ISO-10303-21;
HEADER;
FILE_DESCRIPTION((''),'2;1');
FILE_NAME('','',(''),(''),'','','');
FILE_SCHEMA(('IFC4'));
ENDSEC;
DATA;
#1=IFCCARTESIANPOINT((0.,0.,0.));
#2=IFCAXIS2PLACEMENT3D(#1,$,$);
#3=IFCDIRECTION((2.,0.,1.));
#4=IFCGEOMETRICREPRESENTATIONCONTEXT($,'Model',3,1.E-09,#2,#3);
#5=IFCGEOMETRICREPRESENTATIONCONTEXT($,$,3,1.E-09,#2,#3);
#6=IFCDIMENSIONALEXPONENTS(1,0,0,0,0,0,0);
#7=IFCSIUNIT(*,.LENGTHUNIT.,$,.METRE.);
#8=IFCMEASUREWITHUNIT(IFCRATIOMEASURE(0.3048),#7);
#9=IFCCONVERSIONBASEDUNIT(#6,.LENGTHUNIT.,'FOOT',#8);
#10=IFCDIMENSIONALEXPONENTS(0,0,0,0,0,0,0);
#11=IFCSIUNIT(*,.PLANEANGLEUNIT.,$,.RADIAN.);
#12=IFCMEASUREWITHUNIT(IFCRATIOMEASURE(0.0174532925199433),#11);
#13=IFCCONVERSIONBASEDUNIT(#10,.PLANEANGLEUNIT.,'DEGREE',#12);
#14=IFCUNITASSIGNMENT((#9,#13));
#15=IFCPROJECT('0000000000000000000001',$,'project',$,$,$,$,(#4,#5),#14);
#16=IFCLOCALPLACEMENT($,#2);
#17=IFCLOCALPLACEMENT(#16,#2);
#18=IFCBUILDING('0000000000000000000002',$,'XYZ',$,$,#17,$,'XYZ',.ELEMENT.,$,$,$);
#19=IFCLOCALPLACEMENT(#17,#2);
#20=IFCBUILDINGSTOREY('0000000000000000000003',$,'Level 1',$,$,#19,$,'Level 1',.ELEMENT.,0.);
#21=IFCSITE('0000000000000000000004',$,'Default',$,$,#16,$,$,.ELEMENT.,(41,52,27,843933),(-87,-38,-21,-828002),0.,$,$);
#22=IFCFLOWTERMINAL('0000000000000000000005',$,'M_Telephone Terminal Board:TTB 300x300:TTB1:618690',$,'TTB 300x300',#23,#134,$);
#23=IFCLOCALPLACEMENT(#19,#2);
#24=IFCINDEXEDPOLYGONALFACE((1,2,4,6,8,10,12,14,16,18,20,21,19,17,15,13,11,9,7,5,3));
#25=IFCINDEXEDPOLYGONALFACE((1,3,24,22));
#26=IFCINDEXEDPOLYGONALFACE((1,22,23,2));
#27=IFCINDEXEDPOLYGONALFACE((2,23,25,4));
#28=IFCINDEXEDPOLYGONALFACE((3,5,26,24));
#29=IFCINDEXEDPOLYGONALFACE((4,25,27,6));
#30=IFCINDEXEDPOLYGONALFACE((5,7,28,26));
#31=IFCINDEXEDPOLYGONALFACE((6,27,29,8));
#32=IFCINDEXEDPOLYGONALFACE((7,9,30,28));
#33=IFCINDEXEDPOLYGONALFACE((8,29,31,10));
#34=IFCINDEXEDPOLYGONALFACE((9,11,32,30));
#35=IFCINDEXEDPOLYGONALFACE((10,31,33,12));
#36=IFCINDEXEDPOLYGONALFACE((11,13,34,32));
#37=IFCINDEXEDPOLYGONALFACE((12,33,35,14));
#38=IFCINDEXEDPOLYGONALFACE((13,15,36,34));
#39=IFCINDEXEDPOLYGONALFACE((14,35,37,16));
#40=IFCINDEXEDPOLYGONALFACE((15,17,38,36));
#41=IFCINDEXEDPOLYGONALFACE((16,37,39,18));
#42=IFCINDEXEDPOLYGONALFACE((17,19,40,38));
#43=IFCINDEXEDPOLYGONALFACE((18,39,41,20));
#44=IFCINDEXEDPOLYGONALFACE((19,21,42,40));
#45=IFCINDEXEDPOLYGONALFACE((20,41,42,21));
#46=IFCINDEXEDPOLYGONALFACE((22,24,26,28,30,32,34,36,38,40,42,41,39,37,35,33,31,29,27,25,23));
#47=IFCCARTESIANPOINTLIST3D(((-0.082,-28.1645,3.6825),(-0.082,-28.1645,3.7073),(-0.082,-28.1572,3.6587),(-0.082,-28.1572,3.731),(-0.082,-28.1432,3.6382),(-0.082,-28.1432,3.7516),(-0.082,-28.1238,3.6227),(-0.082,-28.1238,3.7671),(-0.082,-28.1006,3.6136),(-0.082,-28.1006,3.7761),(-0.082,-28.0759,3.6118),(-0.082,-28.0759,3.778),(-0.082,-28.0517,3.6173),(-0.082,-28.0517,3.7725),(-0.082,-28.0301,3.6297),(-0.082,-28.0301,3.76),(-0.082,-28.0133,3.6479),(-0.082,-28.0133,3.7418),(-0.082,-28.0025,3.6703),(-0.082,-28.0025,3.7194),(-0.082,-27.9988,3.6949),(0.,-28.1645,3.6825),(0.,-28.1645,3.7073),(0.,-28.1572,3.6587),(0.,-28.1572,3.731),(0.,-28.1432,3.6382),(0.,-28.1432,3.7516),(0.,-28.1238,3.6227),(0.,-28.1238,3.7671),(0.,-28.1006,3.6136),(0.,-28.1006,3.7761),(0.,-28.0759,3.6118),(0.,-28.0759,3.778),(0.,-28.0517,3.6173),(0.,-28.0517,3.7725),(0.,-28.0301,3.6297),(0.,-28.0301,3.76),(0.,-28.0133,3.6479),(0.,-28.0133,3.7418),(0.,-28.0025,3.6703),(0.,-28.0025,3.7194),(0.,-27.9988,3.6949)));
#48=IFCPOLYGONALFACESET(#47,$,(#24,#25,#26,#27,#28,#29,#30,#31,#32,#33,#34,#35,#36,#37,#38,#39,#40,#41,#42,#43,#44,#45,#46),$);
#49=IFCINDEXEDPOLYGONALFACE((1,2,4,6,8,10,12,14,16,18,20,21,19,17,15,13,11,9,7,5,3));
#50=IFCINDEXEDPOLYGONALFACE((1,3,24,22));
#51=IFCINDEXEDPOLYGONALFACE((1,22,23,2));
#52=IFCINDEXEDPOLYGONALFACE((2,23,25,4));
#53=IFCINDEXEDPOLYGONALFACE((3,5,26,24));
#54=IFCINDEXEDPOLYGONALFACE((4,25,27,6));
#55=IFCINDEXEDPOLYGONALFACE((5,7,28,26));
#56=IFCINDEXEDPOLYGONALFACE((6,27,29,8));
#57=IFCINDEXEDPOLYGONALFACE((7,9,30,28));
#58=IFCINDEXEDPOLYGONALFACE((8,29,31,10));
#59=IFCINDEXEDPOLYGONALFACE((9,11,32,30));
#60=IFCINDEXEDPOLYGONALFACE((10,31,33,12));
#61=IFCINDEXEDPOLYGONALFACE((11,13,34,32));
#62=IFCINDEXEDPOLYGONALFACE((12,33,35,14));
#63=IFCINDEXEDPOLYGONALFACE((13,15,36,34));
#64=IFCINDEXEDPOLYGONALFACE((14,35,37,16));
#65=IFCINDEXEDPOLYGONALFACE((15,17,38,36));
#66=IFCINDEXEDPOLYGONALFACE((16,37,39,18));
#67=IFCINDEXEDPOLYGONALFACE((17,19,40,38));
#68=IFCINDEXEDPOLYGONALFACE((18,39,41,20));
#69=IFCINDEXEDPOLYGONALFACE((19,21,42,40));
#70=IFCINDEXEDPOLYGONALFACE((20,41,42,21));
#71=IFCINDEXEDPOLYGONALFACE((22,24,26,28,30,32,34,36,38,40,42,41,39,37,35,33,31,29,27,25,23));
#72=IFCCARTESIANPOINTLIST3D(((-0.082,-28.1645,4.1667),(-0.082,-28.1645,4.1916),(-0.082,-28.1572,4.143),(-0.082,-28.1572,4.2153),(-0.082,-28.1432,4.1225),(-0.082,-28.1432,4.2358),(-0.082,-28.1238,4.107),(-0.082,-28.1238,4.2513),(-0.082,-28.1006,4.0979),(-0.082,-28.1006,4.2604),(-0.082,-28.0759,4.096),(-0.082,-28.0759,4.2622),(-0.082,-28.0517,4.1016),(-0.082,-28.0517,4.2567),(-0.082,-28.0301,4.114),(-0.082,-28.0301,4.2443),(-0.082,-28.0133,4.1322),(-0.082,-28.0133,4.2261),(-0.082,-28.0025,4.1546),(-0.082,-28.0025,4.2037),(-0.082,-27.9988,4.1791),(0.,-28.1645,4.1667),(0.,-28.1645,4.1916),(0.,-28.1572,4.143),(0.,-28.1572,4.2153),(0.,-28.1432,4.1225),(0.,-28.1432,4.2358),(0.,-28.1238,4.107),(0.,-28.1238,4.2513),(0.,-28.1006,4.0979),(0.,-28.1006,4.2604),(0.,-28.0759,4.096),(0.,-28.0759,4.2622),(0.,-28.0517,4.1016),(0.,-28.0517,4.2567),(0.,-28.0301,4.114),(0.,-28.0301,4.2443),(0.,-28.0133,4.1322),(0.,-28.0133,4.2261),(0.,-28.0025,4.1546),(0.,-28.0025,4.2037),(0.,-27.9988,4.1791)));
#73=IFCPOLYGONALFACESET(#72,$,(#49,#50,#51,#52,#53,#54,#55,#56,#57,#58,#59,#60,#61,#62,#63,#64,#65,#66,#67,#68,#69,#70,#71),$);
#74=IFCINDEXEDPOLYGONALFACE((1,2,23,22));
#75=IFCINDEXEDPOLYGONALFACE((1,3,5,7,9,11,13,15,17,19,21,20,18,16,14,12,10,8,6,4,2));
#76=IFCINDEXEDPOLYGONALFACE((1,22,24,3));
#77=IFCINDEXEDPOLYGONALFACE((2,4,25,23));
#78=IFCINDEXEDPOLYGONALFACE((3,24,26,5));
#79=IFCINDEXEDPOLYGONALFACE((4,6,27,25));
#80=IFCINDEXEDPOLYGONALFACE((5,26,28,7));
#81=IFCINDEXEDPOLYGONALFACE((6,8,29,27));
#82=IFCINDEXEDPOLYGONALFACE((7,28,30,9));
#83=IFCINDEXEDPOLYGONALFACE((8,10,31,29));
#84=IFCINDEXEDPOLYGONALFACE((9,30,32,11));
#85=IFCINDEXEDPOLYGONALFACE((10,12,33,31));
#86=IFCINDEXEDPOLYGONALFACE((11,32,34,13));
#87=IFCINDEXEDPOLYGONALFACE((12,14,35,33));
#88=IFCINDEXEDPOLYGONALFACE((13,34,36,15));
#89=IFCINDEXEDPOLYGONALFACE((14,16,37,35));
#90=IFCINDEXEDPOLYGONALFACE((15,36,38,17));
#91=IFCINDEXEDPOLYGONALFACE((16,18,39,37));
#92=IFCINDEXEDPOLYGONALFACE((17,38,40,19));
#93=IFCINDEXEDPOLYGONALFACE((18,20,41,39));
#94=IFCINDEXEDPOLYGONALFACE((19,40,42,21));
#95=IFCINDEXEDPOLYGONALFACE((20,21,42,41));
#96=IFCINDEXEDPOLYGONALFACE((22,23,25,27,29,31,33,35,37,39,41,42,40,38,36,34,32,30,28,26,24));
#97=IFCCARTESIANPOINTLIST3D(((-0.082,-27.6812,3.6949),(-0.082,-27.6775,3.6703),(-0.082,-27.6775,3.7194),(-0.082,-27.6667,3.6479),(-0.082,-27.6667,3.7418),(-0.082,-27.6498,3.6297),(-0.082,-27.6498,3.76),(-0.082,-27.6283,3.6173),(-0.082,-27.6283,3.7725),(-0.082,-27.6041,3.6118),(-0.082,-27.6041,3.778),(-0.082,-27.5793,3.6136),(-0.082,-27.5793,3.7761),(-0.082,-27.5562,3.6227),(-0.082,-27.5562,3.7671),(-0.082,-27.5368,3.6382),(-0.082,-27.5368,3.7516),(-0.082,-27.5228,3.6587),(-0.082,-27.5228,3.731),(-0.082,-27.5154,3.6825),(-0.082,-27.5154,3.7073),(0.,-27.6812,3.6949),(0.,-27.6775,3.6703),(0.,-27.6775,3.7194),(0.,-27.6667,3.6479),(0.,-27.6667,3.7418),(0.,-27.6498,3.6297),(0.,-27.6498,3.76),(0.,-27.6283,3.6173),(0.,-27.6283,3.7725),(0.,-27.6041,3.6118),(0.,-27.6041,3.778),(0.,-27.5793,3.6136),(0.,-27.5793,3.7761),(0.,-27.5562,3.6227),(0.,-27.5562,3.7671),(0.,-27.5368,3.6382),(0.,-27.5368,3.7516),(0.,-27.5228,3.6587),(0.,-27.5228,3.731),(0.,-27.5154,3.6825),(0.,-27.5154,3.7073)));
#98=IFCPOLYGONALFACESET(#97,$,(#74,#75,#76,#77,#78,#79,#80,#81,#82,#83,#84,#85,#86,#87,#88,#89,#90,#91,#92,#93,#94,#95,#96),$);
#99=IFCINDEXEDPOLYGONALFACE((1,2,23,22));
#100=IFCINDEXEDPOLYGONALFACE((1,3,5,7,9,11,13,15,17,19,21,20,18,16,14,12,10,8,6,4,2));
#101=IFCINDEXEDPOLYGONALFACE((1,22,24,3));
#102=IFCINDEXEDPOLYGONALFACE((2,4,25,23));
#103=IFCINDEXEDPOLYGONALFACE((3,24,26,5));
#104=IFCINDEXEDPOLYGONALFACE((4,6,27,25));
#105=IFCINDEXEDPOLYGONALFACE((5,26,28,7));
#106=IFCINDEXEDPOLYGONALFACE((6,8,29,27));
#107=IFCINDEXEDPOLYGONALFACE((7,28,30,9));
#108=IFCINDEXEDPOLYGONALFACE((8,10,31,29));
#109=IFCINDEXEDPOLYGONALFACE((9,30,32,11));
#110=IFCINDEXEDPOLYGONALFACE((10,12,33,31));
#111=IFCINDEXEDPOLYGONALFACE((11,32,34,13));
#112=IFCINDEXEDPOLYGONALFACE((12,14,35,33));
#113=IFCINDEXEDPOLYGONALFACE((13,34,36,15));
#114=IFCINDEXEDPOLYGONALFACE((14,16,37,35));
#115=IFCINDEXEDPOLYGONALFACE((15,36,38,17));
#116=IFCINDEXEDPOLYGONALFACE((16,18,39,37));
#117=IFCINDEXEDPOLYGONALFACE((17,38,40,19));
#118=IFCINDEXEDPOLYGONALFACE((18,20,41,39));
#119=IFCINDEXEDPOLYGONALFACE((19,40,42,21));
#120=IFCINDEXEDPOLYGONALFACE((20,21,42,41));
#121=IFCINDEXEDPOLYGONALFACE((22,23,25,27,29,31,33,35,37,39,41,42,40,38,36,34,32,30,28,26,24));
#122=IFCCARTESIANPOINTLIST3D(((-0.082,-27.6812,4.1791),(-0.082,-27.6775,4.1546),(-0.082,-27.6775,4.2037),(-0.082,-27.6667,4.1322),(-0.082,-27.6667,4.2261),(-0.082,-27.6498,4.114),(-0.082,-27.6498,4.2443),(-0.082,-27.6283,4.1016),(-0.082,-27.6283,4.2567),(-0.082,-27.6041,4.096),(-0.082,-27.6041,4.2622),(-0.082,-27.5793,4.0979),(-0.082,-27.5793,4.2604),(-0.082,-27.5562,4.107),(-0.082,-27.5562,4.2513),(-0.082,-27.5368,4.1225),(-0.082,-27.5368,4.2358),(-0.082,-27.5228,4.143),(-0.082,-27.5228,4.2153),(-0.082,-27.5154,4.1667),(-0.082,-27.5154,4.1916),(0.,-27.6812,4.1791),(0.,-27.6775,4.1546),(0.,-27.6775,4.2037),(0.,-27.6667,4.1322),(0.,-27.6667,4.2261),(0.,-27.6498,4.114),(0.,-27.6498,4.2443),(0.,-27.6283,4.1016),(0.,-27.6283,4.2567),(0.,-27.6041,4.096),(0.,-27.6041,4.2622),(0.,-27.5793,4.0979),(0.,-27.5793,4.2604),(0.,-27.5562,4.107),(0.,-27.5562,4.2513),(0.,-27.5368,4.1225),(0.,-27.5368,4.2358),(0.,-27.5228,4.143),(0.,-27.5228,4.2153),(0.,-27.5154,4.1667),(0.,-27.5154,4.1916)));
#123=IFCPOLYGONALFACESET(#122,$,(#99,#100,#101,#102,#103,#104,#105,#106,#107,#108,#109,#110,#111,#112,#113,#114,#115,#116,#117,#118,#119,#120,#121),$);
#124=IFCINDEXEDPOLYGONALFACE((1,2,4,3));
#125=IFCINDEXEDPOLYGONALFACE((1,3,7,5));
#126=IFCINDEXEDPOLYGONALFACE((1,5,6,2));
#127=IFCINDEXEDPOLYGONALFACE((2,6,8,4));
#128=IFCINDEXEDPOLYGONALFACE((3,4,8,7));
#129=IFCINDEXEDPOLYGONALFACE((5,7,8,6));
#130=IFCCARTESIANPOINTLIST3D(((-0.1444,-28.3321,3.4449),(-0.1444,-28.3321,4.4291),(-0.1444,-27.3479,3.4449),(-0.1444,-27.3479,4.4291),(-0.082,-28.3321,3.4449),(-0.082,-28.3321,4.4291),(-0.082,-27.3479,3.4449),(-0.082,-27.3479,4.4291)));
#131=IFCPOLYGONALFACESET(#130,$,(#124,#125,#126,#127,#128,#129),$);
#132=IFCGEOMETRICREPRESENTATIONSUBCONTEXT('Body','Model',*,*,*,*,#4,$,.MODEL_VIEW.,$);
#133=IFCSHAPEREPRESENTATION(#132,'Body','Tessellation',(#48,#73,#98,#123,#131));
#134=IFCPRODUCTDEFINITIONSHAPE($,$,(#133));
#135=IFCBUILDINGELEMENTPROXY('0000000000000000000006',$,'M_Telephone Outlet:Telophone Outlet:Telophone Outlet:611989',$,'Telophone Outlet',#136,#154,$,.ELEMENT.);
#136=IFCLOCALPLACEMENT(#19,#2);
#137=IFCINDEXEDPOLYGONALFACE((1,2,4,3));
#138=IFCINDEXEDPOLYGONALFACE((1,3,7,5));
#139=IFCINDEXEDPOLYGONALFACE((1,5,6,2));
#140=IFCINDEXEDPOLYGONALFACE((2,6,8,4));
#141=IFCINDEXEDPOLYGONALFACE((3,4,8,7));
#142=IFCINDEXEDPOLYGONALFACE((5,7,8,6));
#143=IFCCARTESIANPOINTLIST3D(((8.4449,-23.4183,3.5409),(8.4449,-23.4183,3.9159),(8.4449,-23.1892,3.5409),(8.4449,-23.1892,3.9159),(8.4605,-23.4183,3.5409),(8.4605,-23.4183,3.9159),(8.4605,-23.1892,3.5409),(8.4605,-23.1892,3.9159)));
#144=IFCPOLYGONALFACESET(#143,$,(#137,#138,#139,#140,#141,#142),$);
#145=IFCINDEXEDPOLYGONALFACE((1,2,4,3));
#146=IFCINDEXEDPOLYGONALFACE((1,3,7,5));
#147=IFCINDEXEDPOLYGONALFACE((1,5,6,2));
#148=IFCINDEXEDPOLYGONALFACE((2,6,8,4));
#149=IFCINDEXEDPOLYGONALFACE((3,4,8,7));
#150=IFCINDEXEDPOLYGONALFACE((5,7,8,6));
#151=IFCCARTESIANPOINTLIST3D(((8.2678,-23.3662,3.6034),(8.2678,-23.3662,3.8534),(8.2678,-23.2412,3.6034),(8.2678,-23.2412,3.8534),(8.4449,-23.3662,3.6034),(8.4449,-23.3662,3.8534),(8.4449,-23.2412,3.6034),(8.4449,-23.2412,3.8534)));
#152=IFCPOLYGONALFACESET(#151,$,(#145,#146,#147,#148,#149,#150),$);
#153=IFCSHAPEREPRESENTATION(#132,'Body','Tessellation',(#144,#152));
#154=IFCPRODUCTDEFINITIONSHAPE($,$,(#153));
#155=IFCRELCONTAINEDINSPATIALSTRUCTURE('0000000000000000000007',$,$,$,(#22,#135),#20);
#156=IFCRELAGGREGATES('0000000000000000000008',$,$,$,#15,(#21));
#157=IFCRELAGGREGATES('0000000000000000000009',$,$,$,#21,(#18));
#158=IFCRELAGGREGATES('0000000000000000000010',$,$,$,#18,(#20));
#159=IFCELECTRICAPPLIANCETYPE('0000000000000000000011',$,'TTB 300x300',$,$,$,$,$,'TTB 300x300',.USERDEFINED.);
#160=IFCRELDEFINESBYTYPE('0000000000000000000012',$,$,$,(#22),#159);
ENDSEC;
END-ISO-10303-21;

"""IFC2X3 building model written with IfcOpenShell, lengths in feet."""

from ifc_helpers import new_model, entity, si_unit, converted_unit, direction, frame, frame_2d, origin, origin_2d_with_axis, place, context, subcontext, project, spatial, rectangle, circle, extrude, source, transform, mapped, type_object, type_shapes, element, save


model = new_model("IFC2X3")

# Units and contexts
model_context = context("Model", 3, precision=1e-09, world=origin(), true_north=direction((2.0, 0.0, 1.0)))
context_of_model = context(None, 3, precision=1e-09, world=origin(), true_north=direction((2.0, 0.0, 1.0)))
body_context = subcontext(model_context, "Body", "Model", "MODEL_VIEW")
ifc_project = project(units=[converted_unit("LENGTHUNIT", "FOOT", entity("IfcRatioMeasure", 0.3048), si_unit("LENGTHUNIT", "METRE"), dimensions=[1, 0, 0, 0, 0, 0, 0]), converted_unit("PLANEANGLEUNIT", "DEGREE", entity("IfcRatioMeasure", 0.0174532925199433), si_unit("PLANEANGLEUNIT", "RADIAN"), dimensions=[0, 0, 0, 0, 0, 0, 0])], contexts=[model_context, context_of_model])

# Site, building, storey
site_placement = place(None, origin())
site = spatial("IfcSite", under=ifc_project, at=site_placement, Name="Default", CompositionType="ELEMENT", RefLatitude=(41, 52, 27, 843933), RefLongitude=(-87, -38, -21, -828002), RefElevation=0.0)
building_placement = place(site_placement, origin())
building = spatial("IfcBuilding", under=site, at=building_placement, Name="XYZ", LongName="XYZ", CompositionType="ELEMENT")
storey_placement = place(building_placement, origin())
storey = spatial("IfcBuildingStorey", under=building, at=storey_placement, Name="Level 1", LongName="Level 1", CompositionType="ELEMENT", Elevation=0.0)

# Flow terminal
electric_appliance_type_1 = type_object("IfcElectricApplianceType", Name="TTB 300x300", ElementType="TTB 300x300", PredefinedType="USERDEFINED")
shared_shape_1 = source(origin(), body_context, "Body", "SweptSolid", [
    extrude(circle(Radius=0.0833, at=frame_2d((0.0, 0.0), x_axis=(1.0, 0.0))), frame((0.2421, -0.2421, 0.0), z_axis=(0.0, 0.0, 1.0), x_axis=(-1.0, 0.0, 0.0)), (0.0, 0.0, 1.0), 0.082),
    extrude(circle(Radius=0.0833, at=frame_2d((0.0, 0.0), x_axis=(1.0, 0.0))), frame((0.2421, 0.2421, 0.0), z_axis=(0.0, 0.0, 1.0), x_axis=(-1.0, 0.0, 0.0)), (0.0, 0.0, 1.0), 0.082),
    extrude(circle(Radius=0.0833, at=frame_2d((0.0, 0.0), x_axis=(1.0, 0.0))), frame((-0.2421, -0.2421, 0.0)), (0.0, 0.0, 1.0), 0.082),
    extrude(circle(Radius=0.0833, at=frame_2d((0.0, 0.0), x_axis=(1.0, 0.0))), frame((-0.2421, 0.2421, 0.0)), (0.0, 0.0, 1.0), 0.082),
    extrude(rectangle(XDim=0.9843, YDim=0.9843, at=origin_2d_with_axis()), frame((0.0, 0.0, 0.082), z_axis=(0.0, 0.0, 1.0), x_axis=(-1.0, 0.0, 0.0)), (0.0, 0.0, 1.0), 0.0623),
])
type_shapes(electric_appliance_type_1, [shared_shape_1])
flow_terminal_1_placement = place(storey_placement, frame((0.0, -27.84, 3.937), z_axis=(-1.0, 0.0, 0.0), x_axis=(0.0, -1.0, 0.0)))
element("IfcFlowTerminal", 1, at=flow_terminal_1_placement, inside=storey, type_object=electric_appliance_type_1, Name="M_Telephone Terminal Board:TTB 300x300:TTB1:618690", ObjectType="TTB 300x300", context=body_context, shape_type="MappedRepresentation", body=[
    mapped(shared_shape_1, transform((0.0, 0.0, 0.0), scale=1.0)),
])

# Building element proxy
shared_shape_2 = source(origin(), body_context, "Body", "SweptSolid", [
    extrude(rectangle(XDim=0.2292, YDim=0.375, at=frame_2d((0.0, 0.0), x_axis=(1.0, 0.0))), frame((0.0, 0.0, 0.0), z_axis=(0.0, 0.0, 1.0), x_axis=(-1.0, 0.0, 0.0)), (0.0, 0.0, 1.0), 0.0156),
    extrude(rectangle(XDim=0.125, YDim=0.25, at=origin_2d_with_axis()), frame((0.0, 0.0, -0.1771), z_axis=(0.0, 0.0, 1.0), x_axis=(-1.0, 0.0, 0.0)), (0.0, 0.0, 1.0), 0.1771),
])
proxy_placement = place(storey_placement, frame((8.4449, -23.3037, 3.7284), z_axis=(1.0, 0.0, 0.0), x_axis=(0.0, 1.0, 0.0)))
element("IfcBuildingElementProxy", 2, at=proxy_placement, inside=storey, Name="M_Telephone Outlet:Telophone Outlet:Telophone Outlet:611989", ObjectType="Telophone Outlet", CompositionType="ELEMENT", context=body_context, shape_type="MappedRepresentation", body=[
    mapped(shared_shape_2, transform((0.0, 0.0, 0.0), scale=1.0)),
])

save(model, "model.ifc")
